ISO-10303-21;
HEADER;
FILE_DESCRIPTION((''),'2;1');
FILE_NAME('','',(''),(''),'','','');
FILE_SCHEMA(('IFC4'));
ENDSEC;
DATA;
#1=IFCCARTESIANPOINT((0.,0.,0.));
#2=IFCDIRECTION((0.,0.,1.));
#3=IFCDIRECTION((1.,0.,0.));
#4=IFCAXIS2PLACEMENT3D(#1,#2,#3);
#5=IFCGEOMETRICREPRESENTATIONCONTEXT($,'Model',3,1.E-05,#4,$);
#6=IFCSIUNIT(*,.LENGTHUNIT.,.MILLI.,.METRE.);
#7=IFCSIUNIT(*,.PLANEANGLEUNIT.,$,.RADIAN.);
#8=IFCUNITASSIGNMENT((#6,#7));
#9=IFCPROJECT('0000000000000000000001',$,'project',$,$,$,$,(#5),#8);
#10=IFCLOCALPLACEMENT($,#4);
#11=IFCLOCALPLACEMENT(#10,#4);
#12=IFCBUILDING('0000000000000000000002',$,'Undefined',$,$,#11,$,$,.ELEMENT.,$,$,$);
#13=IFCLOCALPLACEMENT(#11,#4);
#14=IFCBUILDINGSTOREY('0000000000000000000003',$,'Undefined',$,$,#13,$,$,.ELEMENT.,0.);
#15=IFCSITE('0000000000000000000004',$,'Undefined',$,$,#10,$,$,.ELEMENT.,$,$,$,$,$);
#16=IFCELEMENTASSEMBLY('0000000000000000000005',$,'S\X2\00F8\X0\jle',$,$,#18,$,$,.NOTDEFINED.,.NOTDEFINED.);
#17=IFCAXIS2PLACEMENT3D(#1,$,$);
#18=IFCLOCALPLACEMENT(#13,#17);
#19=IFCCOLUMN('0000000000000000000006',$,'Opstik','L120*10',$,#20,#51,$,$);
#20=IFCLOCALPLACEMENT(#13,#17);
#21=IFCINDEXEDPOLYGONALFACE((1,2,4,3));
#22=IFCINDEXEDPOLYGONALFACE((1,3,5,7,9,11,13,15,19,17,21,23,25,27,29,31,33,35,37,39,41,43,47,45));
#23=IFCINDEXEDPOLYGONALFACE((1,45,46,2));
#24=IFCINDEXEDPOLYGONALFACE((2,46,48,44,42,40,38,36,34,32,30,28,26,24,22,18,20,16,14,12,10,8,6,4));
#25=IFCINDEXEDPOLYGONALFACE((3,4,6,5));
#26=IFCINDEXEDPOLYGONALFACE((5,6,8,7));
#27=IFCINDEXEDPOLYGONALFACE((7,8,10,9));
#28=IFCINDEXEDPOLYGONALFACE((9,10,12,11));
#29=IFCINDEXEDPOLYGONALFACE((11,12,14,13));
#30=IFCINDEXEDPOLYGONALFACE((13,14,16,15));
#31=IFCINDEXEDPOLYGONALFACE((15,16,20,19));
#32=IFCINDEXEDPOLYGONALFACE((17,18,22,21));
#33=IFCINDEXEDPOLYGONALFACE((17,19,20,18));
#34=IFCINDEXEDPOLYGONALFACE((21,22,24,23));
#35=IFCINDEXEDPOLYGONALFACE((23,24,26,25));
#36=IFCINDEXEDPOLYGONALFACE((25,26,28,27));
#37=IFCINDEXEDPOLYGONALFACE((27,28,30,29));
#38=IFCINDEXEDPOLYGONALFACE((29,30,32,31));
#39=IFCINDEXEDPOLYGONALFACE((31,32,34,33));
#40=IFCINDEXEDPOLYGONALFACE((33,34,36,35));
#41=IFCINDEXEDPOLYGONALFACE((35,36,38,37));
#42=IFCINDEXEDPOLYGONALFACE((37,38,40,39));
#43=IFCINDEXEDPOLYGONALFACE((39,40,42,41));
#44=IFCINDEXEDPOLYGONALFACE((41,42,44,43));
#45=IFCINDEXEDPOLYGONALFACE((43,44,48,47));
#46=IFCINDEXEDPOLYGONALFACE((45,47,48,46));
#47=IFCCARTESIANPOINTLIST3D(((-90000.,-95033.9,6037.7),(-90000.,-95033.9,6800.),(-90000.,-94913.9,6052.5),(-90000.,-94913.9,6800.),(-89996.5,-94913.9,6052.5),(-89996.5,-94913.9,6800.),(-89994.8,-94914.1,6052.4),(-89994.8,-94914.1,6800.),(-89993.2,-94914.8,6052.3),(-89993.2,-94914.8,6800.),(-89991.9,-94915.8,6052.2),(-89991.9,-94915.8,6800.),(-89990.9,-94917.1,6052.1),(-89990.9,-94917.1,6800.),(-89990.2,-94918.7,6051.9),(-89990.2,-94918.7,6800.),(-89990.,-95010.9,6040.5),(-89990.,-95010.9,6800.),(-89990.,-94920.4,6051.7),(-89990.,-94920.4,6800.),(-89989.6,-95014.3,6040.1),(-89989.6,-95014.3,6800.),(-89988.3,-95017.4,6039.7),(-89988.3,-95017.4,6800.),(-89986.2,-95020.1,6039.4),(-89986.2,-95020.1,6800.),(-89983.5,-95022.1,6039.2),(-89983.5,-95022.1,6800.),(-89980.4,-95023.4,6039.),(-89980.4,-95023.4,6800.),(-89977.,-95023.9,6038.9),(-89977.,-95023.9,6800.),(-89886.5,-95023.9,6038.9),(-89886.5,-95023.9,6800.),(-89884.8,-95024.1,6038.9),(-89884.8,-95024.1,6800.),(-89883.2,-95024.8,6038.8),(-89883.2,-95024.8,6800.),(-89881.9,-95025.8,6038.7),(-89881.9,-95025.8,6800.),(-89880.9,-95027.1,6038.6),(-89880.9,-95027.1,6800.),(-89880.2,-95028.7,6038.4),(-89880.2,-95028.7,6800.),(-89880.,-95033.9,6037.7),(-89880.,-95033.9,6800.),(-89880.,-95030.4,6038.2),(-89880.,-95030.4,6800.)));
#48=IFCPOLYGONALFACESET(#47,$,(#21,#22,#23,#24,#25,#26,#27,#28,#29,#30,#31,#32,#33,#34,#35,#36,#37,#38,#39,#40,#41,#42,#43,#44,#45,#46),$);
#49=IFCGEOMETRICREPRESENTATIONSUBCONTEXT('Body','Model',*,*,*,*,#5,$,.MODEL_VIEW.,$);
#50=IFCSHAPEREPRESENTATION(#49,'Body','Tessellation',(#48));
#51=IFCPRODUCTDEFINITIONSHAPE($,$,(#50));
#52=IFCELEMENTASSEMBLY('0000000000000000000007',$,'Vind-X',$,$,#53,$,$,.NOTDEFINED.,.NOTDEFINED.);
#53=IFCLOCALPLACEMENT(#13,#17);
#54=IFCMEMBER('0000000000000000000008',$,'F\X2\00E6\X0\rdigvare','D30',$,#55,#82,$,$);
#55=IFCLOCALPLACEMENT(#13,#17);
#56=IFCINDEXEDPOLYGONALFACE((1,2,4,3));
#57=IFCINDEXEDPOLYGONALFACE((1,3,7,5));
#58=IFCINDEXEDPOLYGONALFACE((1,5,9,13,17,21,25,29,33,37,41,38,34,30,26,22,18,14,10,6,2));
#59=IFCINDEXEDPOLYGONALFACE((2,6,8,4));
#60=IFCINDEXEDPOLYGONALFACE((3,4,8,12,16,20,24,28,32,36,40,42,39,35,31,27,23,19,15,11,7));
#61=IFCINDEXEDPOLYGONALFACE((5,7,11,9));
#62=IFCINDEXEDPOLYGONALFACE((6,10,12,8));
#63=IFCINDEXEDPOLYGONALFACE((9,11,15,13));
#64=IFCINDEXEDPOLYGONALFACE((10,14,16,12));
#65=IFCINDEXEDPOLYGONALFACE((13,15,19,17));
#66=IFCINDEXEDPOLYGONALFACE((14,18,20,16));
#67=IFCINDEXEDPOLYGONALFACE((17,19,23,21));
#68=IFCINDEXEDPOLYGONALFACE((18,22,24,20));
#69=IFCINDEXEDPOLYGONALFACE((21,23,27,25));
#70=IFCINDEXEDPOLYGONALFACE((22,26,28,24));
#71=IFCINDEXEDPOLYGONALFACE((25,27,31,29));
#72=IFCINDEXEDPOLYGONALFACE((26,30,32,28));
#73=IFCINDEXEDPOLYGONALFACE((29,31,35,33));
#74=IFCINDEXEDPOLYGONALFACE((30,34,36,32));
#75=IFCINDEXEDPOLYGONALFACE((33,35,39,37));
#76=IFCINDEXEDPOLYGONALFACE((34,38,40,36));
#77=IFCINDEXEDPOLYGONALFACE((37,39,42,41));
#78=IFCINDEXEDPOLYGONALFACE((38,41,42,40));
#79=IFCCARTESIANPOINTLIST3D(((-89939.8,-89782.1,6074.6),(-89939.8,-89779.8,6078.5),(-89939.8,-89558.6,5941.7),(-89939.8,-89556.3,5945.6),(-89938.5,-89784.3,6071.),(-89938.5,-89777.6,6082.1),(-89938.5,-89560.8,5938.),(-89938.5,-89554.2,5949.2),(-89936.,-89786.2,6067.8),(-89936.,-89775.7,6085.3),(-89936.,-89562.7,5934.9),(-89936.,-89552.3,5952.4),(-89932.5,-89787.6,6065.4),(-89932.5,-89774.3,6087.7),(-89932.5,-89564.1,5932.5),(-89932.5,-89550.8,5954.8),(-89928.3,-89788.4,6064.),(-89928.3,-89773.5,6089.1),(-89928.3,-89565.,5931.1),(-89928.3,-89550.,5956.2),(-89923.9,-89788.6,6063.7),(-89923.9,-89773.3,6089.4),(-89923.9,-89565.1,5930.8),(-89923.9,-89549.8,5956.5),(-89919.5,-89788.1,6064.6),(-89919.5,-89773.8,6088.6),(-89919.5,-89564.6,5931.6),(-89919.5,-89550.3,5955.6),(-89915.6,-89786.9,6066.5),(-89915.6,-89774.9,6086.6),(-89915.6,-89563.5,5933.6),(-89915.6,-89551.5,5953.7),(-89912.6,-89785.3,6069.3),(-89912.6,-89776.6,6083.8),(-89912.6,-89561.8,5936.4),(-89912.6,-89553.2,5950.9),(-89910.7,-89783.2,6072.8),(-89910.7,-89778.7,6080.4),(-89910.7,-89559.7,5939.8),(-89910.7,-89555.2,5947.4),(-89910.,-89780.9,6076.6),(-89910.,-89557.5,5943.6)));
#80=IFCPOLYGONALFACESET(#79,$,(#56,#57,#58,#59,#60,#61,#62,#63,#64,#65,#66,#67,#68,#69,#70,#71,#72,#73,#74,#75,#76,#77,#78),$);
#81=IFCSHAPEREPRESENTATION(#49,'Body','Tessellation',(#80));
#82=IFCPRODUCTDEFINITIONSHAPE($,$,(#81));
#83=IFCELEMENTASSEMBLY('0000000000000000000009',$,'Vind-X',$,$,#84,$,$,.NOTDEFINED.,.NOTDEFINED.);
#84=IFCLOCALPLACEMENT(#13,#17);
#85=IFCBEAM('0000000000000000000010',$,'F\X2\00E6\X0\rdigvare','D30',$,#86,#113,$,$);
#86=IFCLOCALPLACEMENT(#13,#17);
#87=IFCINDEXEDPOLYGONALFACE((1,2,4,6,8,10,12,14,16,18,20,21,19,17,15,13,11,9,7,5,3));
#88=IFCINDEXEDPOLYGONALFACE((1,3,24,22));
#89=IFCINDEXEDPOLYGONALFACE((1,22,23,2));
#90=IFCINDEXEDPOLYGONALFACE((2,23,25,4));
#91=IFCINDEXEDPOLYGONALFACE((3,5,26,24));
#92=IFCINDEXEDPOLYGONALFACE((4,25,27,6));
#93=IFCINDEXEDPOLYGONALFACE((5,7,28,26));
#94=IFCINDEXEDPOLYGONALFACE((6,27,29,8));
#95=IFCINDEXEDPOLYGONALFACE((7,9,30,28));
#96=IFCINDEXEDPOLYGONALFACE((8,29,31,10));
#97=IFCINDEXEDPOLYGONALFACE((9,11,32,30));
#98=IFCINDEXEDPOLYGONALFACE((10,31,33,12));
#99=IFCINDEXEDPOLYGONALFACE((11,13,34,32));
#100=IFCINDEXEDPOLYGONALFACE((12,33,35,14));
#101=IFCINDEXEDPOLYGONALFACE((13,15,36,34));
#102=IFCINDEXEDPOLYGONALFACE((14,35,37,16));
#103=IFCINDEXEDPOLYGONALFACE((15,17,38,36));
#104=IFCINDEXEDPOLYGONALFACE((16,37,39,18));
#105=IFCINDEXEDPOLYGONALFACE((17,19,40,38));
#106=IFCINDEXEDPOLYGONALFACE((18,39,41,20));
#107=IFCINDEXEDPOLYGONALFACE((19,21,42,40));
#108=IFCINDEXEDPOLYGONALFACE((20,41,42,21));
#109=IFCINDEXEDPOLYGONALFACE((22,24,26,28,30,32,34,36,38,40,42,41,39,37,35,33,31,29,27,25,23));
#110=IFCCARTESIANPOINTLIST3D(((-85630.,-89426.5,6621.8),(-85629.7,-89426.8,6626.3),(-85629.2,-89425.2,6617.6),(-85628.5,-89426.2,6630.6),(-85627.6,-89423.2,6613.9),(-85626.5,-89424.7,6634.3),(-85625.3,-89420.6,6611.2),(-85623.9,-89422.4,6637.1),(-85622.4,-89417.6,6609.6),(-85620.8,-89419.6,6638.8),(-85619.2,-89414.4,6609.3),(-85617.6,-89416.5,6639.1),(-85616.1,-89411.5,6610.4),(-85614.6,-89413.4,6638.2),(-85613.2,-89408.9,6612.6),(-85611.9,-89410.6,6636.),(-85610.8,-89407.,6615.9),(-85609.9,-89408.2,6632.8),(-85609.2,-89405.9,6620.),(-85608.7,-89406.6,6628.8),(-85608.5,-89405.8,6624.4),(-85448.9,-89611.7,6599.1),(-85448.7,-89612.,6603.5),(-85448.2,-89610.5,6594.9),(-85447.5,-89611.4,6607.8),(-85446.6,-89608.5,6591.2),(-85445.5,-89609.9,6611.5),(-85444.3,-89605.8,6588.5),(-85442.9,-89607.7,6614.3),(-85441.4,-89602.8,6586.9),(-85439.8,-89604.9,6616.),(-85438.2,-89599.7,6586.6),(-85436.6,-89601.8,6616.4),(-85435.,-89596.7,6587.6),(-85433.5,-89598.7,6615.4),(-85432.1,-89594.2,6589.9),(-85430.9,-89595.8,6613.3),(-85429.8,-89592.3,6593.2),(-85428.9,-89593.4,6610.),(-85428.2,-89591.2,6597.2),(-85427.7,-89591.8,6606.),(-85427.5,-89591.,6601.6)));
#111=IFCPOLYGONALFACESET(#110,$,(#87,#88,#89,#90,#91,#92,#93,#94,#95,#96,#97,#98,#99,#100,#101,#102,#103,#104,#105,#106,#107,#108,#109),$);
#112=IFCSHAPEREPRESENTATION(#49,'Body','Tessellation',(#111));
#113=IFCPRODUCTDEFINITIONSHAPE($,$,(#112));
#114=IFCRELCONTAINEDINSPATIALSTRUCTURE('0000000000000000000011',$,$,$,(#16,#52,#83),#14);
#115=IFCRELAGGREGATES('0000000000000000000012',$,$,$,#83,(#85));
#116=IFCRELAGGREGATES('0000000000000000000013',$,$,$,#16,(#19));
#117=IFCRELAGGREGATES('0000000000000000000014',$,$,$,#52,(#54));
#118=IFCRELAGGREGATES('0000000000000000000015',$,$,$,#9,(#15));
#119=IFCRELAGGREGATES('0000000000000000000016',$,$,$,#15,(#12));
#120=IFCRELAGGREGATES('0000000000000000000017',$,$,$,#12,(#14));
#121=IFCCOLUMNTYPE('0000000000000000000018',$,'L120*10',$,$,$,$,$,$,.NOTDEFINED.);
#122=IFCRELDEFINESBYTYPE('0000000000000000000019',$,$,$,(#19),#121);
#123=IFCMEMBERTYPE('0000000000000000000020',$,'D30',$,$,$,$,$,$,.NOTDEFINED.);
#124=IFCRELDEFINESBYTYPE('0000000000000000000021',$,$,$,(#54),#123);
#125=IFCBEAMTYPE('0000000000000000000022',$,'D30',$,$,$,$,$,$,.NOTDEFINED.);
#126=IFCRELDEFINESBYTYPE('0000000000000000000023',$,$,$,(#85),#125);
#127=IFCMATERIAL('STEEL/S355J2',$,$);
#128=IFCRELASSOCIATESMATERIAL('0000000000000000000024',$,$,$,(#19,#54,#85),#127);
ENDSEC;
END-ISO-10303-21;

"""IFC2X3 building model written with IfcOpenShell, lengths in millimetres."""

from ifc_helpers import new_model, si_unit, frame, origin_with_axes, origin_2d_with_axis, place, context, subcontext, project, spatial, circle, l_section, extrude, clip, halfspace, material, type_object, element, aggregate, save


model = new_model("IFC2X3")

# Units and contexts
model_context = context("Model", 3, precision=1e-05, world=origin_with_axes())
body_context = subcontext(model_context, "Body", "Model", "MODEL_VIEW")
ifc_project = project(units=[si_unit("LENGTHUNIT", "METRE", prefix="MILLI"), si_unit("PLANEANGLEUNIT", "RADIAN")], contexts=[model_context])

# Site, building, storey
site_placement = place(None, origin_with_axes())
site = spatial("IfcSite", under=ifc_project, at=site_placement, Name="Undefined", CompositionType="ELEMENT")
building_placement = place(site_placement, origin_with_axes())
building = spatial("IfcBuilding", under=site, at=building_placement, Name="Undefined", CompositionType="ELEMENT")
storey_placement = place(building_placement, origin_with_axes())
storey = spatial("IfcBuildingStorey", under=building, at=storey_placement, Name="Undefined", CompositionType="ELEMENT", Elevation=0.0)

# Element assembly, column
assembly_1_placement = place(storey_placement, origin_with_axes())
assembly_1 = element("IfcElementAssembly", 1, at=assembly_1_placement, inside=storey, Name="Søjle", AssemblyPlace="NOTDEFINED", PredefinedType="NOTDEFINED")
ifc_material_1 = material(Name="STEEL/S355J2")
column_type_1 = type_object("IfcColumnType", Name="L120*10", PredefinedType="NOTDEFINED")
column_1_placement = place(assembly_1_placement, frame((-89940.0, -94973.9, 6000.0), z_axis=(0.0, 0.0, 1.0), x_axis=(1.0, 0.0, 0.0)))
column_1 = element("IfcColumn", 2, at=column_1_placement, type_object=column_type_1, material=ifc_material_1, Name="Opstik", Description="L120*10", context=body_context, shape_type="Clipping", body=[
    clip(extrude(l_section(Depth=120.0, Width=120.0, Thickness=10.0, FilletRadius=13.0, EdgeRadius=6.5, at=origin_2d_with_axis()), frame((0.0, 0.0, 800.0), z_axis=(0.0, 0.0, -1.0), x_axis=(0.0, 1.0, 0.0)), (0.0, 0.0, 1.0), 800.0), halfspace(frame((-60.0, -60.0, 37.7), z_axis=(0.0, 0.121872, -0.992546), x_axis=(1.0, 0.0, 0.0)), False)),
])

# Element assembly, member
assembly_2_placement = place(storey_placement, origin_with_axes())
assembly_2 = element("IfcElementAssembly", 3, at=assembly_2_placement, inside=storey, Name="Vind-X", AssemblyPlace="NOTDEFINED", PredefinedType="NOTDEFINED")
member_type_1 = type_object("IfcMemberType", Name="D30", PredefinedType="NOTDEFINED")
member_1_placement = place(assembly_2_placement, frame((-89925.0, -89780.9, 6076.6), z_axis=(0.0, 0.511223, 0.859448), x_axis=(0.0, 0.859448, -0.511223)))
member_1 = element("IfcMember", 4, at=member_1_placement, type_object=member_type_1, material=ifc_material_1, Name="Færdigvare", Description="D30", context=body_context, shape_type="SweptSolid", body=[
    extrude(circle(Radius=15.0, at=origin_2d_with_axis()), frame((260.0, 0.0, 0.0), z_axis=(-1.0, 0.0, 0.0), x_axis=(0.0, -1.0, 0.0)), (0.0, 0.0, 1.0), 260.0),
])

# Element assembly, beam
assembly_3_placement = place(storey_placement, origin_with_axes())
assembly_3 = element("IfcElementAssembly", 5, at=assembly_3_placement, inside=storey, Name="Vind-X", AssemblyPlace="NOTDEFINED", PredefinedType="NOTDEFINED")
beam_type_1 = type_object("IfcBeamType", Name="D30", PredefinedType="NOTDEFINED")
beam_1_placement = place(assembly_3_placement, frame((-85438.2, -89601.5, 6601.5), z_axis=(0.717842, 0.691016, 0.084846), x_axis=(-0.696206, 0.712492, 0.087483)))
beam_1 = element("IfcBeam", 6, at=beam_1_placement, type_object=beam_type_1, material=ifc_material_1, Name="Færdigvare", Description="D30", context=body_context, shape_type="SweptSolid", body=[
    extrude(circle(Radius=15.0, at=origin_2d_with_axis()), frame((260.0, 0.0, 0.0), z_axis=(-1.0, 0.0, 0.0), x_axis=(0.0, -1.0, 0.0)), (0.0, 0.0, 1.0), 260.0),
])
aggregate(assembly_3, [beam_1])

aggregate(assembly_1, [column_1])

aggregate(assembly_2, [member_1])

save(model, "model.ifc")
